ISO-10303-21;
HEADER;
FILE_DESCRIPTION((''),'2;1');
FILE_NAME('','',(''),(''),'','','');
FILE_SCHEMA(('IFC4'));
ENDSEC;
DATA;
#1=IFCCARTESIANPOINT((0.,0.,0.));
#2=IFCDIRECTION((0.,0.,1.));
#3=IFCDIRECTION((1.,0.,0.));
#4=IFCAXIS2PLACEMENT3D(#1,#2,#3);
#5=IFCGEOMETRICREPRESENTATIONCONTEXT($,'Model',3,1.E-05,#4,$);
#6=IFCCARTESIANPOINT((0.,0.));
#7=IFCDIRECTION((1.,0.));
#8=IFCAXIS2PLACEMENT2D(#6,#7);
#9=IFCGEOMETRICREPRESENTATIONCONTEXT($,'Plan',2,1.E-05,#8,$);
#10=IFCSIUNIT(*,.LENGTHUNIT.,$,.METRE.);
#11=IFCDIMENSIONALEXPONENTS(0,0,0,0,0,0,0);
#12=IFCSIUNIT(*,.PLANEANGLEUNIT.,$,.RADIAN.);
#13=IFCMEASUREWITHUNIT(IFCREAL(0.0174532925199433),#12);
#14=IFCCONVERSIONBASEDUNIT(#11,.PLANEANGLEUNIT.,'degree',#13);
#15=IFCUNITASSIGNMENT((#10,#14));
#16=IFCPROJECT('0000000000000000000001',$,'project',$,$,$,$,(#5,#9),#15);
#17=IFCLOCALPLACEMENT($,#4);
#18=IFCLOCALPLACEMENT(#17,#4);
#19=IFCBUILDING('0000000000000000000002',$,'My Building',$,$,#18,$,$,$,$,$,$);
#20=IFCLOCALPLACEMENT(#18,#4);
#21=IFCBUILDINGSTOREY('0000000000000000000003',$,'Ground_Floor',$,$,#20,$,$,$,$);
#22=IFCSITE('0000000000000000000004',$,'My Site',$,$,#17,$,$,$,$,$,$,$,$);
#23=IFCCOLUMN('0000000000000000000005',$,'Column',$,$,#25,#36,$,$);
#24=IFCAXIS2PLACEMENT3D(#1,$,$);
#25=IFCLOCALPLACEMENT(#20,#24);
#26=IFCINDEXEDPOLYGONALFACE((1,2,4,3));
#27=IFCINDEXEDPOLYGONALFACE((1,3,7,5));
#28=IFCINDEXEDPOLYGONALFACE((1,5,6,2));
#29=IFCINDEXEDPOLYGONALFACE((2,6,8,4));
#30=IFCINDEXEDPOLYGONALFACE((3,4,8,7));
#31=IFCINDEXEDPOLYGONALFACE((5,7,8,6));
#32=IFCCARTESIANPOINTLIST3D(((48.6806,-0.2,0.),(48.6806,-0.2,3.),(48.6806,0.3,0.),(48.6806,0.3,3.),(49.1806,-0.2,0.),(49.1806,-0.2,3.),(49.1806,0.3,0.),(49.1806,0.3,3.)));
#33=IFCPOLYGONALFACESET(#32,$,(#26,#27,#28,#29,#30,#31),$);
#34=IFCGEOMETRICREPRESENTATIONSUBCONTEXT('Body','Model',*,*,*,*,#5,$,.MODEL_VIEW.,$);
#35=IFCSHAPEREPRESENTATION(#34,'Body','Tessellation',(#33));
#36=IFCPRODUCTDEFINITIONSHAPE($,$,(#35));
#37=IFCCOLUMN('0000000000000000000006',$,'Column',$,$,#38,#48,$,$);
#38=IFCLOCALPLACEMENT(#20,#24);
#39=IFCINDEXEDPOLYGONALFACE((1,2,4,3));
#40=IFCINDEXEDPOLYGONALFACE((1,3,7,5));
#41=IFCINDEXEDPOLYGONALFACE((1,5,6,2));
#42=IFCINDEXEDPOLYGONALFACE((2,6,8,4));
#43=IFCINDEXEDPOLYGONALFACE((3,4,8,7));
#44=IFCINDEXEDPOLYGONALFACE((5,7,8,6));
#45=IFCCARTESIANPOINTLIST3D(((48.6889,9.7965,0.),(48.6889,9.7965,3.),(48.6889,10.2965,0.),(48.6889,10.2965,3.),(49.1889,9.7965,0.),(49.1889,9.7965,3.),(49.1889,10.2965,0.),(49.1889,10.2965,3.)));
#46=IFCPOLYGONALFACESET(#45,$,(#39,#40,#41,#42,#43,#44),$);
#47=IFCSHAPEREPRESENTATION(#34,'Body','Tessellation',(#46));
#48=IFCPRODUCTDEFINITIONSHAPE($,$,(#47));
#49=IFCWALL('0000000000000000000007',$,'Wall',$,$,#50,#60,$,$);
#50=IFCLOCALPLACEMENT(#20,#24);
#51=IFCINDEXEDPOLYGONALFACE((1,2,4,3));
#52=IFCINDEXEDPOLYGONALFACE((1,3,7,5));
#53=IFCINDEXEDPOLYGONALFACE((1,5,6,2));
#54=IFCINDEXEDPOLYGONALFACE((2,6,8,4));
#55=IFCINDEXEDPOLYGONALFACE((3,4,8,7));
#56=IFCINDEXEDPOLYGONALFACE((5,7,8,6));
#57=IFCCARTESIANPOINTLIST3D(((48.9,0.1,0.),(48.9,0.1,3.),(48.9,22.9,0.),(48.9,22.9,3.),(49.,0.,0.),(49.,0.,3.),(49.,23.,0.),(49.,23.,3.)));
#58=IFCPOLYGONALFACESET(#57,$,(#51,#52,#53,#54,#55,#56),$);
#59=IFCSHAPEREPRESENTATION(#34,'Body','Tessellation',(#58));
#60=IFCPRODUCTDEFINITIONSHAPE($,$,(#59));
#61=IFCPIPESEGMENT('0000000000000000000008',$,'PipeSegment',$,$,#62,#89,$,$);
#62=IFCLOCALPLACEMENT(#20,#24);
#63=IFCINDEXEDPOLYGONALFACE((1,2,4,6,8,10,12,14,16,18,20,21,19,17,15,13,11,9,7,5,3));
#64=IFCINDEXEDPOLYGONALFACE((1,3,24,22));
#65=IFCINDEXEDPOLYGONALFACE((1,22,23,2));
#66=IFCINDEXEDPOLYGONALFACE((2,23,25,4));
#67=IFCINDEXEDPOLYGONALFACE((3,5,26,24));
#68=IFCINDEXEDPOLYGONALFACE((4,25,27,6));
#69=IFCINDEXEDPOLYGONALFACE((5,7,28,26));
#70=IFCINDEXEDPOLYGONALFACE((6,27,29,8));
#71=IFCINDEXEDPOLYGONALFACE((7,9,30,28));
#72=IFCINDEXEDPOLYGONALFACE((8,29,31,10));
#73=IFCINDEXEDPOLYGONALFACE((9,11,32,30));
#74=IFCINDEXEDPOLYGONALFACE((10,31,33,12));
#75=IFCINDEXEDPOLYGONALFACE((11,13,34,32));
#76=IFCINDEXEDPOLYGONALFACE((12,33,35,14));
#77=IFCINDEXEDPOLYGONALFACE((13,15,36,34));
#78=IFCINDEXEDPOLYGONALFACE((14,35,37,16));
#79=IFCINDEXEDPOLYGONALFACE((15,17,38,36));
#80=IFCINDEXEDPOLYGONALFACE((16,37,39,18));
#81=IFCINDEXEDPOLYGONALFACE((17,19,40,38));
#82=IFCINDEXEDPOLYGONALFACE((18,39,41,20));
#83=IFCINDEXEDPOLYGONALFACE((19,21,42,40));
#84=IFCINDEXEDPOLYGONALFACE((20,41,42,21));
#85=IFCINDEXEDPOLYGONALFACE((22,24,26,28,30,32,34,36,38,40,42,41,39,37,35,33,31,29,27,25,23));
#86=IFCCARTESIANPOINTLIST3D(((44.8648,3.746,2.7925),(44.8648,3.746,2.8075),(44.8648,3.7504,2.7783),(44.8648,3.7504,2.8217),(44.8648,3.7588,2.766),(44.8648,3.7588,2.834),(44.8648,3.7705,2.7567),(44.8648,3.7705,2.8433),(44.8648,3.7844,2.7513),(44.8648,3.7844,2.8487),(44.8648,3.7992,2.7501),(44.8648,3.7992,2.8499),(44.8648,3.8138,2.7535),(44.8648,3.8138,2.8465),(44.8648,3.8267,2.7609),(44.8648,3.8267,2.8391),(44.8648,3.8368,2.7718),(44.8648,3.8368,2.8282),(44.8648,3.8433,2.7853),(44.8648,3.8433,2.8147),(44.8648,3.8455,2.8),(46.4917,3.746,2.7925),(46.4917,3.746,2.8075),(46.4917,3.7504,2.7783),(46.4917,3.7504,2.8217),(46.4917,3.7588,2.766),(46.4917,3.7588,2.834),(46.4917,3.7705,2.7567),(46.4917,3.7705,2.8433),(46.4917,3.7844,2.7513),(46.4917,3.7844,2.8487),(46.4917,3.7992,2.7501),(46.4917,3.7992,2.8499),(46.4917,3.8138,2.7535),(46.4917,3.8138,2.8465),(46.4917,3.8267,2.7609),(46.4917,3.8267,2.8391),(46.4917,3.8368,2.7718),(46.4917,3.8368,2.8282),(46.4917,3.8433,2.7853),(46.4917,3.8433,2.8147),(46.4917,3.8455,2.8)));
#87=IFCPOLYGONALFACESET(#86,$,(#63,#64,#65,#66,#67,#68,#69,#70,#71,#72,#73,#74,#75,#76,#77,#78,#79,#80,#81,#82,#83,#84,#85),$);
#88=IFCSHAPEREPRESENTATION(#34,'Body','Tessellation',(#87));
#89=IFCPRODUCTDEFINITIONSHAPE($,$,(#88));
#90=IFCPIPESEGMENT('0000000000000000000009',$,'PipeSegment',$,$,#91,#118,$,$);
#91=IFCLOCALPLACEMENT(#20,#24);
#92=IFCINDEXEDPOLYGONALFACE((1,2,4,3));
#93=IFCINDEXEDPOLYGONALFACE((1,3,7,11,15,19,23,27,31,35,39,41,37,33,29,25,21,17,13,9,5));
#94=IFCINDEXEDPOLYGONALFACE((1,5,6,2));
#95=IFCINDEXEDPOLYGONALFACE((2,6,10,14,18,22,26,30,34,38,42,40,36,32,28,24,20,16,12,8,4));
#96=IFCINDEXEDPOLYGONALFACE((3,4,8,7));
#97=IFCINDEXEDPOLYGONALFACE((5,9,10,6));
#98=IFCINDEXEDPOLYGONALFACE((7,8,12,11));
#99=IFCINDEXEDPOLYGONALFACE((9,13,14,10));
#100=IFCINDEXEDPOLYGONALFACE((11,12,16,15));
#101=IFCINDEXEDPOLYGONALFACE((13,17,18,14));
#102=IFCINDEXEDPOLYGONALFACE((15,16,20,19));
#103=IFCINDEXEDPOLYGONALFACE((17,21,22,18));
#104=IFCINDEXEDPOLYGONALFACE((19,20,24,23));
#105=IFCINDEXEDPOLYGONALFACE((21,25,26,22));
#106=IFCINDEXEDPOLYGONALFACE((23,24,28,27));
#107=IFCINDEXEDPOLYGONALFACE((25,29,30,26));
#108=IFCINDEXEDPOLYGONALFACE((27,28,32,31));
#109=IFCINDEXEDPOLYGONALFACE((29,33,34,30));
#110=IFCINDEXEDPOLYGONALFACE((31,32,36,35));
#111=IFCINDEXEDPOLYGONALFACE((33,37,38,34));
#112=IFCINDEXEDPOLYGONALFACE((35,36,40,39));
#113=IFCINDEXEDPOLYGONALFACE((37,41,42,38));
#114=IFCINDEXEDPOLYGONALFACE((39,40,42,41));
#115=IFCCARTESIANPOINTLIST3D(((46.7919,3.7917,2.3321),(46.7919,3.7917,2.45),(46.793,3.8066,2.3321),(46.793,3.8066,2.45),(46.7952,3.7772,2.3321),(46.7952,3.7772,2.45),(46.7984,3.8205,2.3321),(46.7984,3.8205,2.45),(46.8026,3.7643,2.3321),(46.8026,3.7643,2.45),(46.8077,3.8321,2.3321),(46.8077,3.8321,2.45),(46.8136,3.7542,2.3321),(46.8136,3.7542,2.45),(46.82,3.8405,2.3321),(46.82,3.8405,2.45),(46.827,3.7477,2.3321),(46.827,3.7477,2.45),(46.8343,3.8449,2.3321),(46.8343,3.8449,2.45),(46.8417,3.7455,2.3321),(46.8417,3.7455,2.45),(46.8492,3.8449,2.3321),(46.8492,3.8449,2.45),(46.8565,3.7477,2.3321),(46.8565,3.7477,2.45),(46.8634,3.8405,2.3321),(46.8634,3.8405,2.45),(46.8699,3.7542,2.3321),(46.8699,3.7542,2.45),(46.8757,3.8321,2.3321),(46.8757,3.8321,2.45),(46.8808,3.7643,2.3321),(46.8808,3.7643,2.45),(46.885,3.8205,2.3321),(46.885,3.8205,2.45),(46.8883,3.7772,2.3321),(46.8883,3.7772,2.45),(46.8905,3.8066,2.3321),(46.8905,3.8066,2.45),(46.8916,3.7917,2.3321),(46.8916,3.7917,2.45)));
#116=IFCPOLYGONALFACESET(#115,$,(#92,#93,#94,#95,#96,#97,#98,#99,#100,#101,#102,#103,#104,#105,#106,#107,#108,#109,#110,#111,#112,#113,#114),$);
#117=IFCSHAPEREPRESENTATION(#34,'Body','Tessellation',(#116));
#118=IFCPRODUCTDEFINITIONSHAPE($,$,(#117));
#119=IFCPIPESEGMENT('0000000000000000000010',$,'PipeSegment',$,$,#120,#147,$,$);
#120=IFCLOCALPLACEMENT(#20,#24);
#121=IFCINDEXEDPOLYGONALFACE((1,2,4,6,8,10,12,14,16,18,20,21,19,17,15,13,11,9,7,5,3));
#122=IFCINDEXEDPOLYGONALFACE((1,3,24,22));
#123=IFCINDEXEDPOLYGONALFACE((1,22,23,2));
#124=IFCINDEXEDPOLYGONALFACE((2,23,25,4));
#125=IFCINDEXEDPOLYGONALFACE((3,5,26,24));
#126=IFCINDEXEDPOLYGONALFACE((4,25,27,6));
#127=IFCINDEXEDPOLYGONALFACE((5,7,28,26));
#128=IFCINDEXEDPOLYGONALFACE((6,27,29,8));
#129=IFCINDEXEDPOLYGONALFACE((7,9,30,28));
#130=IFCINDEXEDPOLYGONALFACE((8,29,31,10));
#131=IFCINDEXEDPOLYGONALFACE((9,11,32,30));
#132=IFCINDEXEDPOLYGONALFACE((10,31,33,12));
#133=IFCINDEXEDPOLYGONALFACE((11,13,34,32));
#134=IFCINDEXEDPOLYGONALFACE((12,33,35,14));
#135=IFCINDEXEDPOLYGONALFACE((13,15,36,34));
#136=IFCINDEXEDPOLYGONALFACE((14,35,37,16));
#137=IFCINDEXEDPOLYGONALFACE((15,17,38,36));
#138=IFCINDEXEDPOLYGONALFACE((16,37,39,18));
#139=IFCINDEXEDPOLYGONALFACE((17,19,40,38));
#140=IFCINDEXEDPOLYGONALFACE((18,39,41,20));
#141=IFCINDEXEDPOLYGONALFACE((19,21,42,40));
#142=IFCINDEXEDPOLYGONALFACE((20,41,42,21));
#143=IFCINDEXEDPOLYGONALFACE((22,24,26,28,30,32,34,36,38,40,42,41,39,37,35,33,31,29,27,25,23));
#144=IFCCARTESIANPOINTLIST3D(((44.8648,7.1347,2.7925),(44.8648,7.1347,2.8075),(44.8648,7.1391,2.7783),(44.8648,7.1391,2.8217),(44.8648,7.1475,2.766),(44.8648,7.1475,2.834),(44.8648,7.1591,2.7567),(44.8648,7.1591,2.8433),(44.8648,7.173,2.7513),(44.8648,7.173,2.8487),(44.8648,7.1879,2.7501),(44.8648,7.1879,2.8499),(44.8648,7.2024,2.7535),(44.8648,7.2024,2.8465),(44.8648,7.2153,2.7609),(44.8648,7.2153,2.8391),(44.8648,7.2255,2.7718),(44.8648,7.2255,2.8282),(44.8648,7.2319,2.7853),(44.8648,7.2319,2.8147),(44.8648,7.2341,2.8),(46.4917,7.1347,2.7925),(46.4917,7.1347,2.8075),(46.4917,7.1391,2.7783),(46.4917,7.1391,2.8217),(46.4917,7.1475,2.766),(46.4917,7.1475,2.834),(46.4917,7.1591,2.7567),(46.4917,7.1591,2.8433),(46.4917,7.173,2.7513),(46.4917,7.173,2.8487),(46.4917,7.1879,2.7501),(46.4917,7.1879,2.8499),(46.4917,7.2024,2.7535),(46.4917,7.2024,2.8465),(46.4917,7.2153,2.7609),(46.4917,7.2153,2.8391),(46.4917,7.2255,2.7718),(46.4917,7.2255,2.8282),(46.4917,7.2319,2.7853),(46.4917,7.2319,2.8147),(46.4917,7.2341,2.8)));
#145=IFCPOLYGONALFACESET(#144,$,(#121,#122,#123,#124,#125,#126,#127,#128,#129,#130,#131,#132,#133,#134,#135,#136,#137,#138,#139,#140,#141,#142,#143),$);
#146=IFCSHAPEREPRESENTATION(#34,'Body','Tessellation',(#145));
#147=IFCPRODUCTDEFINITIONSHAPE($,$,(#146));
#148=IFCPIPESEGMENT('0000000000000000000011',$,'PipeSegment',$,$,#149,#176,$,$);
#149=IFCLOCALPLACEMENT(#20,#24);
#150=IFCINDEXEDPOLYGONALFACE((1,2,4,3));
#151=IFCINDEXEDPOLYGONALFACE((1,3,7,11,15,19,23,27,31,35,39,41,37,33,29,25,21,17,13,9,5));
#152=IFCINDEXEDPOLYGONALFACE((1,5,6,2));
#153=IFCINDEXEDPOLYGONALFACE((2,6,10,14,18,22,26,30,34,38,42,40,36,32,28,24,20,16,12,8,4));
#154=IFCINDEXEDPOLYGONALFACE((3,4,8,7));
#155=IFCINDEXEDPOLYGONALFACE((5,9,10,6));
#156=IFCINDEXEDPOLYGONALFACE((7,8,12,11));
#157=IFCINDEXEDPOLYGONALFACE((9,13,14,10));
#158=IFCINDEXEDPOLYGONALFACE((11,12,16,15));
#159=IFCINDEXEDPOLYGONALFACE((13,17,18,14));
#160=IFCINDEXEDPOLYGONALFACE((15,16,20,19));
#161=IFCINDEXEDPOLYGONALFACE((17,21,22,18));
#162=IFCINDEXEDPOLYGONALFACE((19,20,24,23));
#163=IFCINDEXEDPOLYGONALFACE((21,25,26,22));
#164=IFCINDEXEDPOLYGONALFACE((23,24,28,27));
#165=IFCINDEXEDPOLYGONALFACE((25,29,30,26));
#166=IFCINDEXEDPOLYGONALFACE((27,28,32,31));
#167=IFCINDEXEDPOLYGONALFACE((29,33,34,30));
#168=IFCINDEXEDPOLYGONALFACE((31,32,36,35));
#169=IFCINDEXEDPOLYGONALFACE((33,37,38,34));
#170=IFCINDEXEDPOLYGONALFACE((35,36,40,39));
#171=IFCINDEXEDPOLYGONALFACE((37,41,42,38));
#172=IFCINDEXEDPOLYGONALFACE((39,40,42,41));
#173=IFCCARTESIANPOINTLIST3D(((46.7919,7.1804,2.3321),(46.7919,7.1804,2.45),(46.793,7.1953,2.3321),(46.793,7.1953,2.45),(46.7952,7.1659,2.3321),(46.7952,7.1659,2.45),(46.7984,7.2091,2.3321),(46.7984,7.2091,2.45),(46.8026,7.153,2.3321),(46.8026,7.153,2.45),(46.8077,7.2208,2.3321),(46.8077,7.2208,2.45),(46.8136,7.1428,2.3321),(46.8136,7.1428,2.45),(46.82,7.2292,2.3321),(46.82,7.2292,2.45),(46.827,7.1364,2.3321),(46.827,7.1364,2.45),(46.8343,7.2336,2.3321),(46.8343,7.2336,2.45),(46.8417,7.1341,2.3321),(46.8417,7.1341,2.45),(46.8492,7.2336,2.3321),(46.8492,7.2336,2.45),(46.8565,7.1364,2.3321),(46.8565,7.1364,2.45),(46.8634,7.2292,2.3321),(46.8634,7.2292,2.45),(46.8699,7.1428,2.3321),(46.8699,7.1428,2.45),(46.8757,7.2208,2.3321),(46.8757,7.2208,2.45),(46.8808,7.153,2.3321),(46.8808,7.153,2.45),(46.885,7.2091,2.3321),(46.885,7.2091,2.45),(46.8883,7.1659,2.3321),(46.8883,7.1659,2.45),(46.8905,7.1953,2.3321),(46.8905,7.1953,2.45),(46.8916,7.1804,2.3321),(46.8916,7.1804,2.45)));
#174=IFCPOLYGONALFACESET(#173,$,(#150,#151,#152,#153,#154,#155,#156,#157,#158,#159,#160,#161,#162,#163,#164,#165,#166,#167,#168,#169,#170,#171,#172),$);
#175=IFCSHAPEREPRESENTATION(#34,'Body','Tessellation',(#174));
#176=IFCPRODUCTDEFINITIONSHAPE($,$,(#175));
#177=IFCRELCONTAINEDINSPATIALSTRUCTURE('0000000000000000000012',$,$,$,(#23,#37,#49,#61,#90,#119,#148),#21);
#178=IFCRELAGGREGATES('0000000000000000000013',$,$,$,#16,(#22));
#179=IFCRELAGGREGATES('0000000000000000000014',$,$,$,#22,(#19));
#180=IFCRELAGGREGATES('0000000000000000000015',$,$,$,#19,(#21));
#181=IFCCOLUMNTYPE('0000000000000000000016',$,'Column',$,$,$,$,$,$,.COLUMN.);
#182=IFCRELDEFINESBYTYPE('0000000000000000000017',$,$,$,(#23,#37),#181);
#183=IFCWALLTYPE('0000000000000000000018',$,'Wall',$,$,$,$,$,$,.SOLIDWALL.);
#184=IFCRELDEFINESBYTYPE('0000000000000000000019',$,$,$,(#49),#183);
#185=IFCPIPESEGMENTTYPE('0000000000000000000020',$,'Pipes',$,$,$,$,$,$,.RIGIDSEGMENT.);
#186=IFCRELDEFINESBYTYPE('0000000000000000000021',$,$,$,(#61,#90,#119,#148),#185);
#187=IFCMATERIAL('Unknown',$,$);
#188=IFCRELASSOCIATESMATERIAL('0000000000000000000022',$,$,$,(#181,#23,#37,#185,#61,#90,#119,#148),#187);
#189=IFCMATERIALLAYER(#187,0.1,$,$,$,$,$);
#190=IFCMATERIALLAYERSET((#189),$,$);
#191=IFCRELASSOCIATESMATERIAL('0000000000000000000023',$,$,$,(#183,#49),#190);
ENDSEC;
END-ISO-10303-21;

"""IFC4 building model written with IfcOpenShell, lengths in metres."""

from ifc_helpers import new_model, entity, si_unit, converted_unit, frame, origin_with_axes, origin_2d_with_axis, place, context, subcontext, project, spatial, line, indexed_curve, rectangle, circle, outline, extrude, material, layer, layer_set, layer_usage, material_profile, profile_set, profile_usage, type_object, element, save


model = new_model("IFC4")

# Units and contexts
model_context = context("Model", 3, precision=1e-05, world=origin_with_axes())
plan_context = context("Plan", 2, precision=1e-05, world=origin_2d_with_axis())
body_context = subcontext(model_context, "Body", "Model", "MODEL_VIEW")
ifc_project = project(units=[si_unit("LENGTHUNIT", "METRE"), converted_unit("PLANEANGLEUNIT", "degree", entity("IfcReal", 0.0174532925199433), si_unit("PLANEANGLEUNIT", "RADIAN"), dimensions=[0, 0, 0, 0, 0, 0, 0])], contexts=[model_context, plan_context])

# Site, building, storey
site_placement = place(None, origin_with_axes())
site = spatial("IfcSite", under=ifc_project, at=site_placement, Name="My Site")
building_placement = place(site_placement, origin_with_axes())
building = spatial("IfcBuilding", under=site, at=building_placement, Name="My Building")
storey_placement = place(building_placement, origin_with_axes())
storey = spatial("IfcBuildingStorey", under=building, at=storey_placement, Name="Ground_Floor")

# Columns
ifc_material = material(Name="Unknown")
ifc_material_profile_1 = material_profile(ifc_material, rectangle(XDim=0.5, YDim=0.5))
ifc_profile_set_1 = profile_set([ifc_material_profile_1])
ifc_profile_usage_1 = profile_usage(ifc_profile_set_1, cardinal=5)
column_type = type_object("IfcColumnType", Name="Column", PredefinedType="COLUMN", material=ifc_profile_set_1)
column_1_placement = place(storey_placement, frame((48.9306, 0.05, 0.0), z_axis=(0.0, 0.0, 1.0), x_axis=(1.0, 0.0, 0.0)))
element("IfcColumn", 1, at=column_1_placement, inside=storey, type_object=column_type, material=ifc_profile_usage_1, Name="Column", context=body_context, shape_type="SweptSolid", body=[
    extrude(rectangle(XDim=0.5, YDim=0.5), origin_with_axes(), (0.0, 0.0, 1.0), 3.0),
])
ifc_profile_usage_2 = profile_usage(ifc_profile_set_1, cardinal=5)
column_2_placement = place(storey_placement, frame((48.9389, 10.0465, 0.0), z_axis=(0.0, 0.0, 1.0), x_axis=(1.0, 0.0, 0.0)))
element("IfcColumn", 2, at=column_2_placement, inside=storey, type_object=column_type, material=ifc_profile_usage_2, Name="Column", context=body_context, shape_type="SweptSolid", body=[
    extrude(rectangle(XDim=0.5, YDim=0.5), origin_with_axes(), (0.0, 0.0, 1.0), 3.0),
])

# Wall
ifc_layer = layer(ifc_material, 0.1)
ifc_layer_set = layer_set([ifc_layer])
ifc_layer_usage = layer_usage(ifc_layer_set, "AXIS2", "POSITIVE", 0.0)
wall_type = type_object("IfcWallType", Name="Wall", PredefinedType="SOLIDWALL", material=ifc_layer_set)
wall_placement = place(storey_placement, frame((49.0, 0.0, 0.0), z_axis=(0.0, 0.0, 1.0), x_axis=(0.0, 1.0, 0.0)))
element("IfcWall", 3, at=wall_placement, inside=storey, type_object=wall_type, material=ifc_layer_usage, Name="Wall", context=body_context, shape_type="SweptSolid", body=[
    extrude(outline(indexed_curve([(0.0, 0.0), (0.1, 0.1), (22.9, 0.1), (23.0, 0.0)], segments=[line(1, 2, 3, 4, 1)])), origin_with_axes(), (0.0, 0.0, 1.0), 3.0),
])

# Pipe segments
ifc_material_profile_2 = material_profile(ifc_material, circle(Radius=0.05))
ifc_profile_set_2 = profile_set([ifc_material_profile_2])
ifc_profile_usage_3 = profile_usage(ifc_profile_set_2, cardinal=5)
pipe_segment_type = type_object("IfcPipeSegmentType", Name="Pipes", PredefinedType="RIGIDSEGMENT", material=ifc_profile_set_2)
pipe_segment_1_placement = place(storey_placement, frame((44.8648, 3.7955, 2.8), z_axis=(1.0, 0.0, 0.0), x_axis=(0.0, 1.0, 0.0)))
element("IfcPipeSegment", 4, at=pipe_segment_1_placement, inside=storey, type_object=pipe_segment_type, material=ifc_profile_usage_3, Name="PipeSegment", context=body_context, shape_type="SweptSolid", body=[
    extrude(circle(Radius=0.05), origin_with_axes(), (0.0, 0.0, 1.0), 1.6269),
])
ifc_profile_usage_4 = profile_usage(ifc_profile_set_2, cardinal=5)
pipe_segment_2_placement = place(storey_placement, frame((46.8417, 3.7955, 2.45), z_axis=(0.0, 0.0, -1.0), x_axis=(0.0, -1.0, 0.0)))
element("IfcPipeSegment", 5, at=pipe_segment_2_placement, inside=storey, type_object=pipe_segment_type, material=ifc_profile_usage_4, Name="PipeSegment", context=body_context, shape_type="SweptSolid", body=[
    extrude(circle(Radius=0.05), origin_with_axes(), (0.0, 0.0, 1.0), 0.1179),
])
ifc_profile_usage_5 = profile_usage(ifc_profile_set_2, cardinal=5)
pipe_segment_3_placement = place(storey_placement, frame((44.8648, 7.1841, 2.8), z_axis=(1.0, 0.0, 0.0), x_axis=(0.0, 1.0, 0.0)))
element("IfcPipeSegment", 6, at=pipe_segment_3_placement, inside=storey, type_object=pipe_segment_type, material=ifc_profile_usage_5, Name="PipeSegment", context=body_context, shape_type="SweptSolid", body=[
    extrude(circle(Radius=0.05), origin_with_axes(), (0.0, 0.0, 1.0), 1.6269),
])
ifc_profile_usage_6 = profile_usage(ifc_profile_set_2, cardinal=5)
pipe_segment_4_placement = place(storey_placement, frame((46.8417, 7.1841, 2.45), z_axis=(0.0, 0.0, -1.0), x_axis=(0.0, -1.0, 0.0)))
element("IfcPipeSegment", 7, at=pipe_segment_4_placement, inside=storey, type_object=pipe_segment_type, material=ifc_profile_usage_6, Name="PipeSegment", context=body_context, shape_type="SweptSolid", body=[
    extrude(circle(Radius=0.05), origin_with_axes(), (0.0, 0.0, 1.0), 0.1179),
])

save(model, "model.ifc")
